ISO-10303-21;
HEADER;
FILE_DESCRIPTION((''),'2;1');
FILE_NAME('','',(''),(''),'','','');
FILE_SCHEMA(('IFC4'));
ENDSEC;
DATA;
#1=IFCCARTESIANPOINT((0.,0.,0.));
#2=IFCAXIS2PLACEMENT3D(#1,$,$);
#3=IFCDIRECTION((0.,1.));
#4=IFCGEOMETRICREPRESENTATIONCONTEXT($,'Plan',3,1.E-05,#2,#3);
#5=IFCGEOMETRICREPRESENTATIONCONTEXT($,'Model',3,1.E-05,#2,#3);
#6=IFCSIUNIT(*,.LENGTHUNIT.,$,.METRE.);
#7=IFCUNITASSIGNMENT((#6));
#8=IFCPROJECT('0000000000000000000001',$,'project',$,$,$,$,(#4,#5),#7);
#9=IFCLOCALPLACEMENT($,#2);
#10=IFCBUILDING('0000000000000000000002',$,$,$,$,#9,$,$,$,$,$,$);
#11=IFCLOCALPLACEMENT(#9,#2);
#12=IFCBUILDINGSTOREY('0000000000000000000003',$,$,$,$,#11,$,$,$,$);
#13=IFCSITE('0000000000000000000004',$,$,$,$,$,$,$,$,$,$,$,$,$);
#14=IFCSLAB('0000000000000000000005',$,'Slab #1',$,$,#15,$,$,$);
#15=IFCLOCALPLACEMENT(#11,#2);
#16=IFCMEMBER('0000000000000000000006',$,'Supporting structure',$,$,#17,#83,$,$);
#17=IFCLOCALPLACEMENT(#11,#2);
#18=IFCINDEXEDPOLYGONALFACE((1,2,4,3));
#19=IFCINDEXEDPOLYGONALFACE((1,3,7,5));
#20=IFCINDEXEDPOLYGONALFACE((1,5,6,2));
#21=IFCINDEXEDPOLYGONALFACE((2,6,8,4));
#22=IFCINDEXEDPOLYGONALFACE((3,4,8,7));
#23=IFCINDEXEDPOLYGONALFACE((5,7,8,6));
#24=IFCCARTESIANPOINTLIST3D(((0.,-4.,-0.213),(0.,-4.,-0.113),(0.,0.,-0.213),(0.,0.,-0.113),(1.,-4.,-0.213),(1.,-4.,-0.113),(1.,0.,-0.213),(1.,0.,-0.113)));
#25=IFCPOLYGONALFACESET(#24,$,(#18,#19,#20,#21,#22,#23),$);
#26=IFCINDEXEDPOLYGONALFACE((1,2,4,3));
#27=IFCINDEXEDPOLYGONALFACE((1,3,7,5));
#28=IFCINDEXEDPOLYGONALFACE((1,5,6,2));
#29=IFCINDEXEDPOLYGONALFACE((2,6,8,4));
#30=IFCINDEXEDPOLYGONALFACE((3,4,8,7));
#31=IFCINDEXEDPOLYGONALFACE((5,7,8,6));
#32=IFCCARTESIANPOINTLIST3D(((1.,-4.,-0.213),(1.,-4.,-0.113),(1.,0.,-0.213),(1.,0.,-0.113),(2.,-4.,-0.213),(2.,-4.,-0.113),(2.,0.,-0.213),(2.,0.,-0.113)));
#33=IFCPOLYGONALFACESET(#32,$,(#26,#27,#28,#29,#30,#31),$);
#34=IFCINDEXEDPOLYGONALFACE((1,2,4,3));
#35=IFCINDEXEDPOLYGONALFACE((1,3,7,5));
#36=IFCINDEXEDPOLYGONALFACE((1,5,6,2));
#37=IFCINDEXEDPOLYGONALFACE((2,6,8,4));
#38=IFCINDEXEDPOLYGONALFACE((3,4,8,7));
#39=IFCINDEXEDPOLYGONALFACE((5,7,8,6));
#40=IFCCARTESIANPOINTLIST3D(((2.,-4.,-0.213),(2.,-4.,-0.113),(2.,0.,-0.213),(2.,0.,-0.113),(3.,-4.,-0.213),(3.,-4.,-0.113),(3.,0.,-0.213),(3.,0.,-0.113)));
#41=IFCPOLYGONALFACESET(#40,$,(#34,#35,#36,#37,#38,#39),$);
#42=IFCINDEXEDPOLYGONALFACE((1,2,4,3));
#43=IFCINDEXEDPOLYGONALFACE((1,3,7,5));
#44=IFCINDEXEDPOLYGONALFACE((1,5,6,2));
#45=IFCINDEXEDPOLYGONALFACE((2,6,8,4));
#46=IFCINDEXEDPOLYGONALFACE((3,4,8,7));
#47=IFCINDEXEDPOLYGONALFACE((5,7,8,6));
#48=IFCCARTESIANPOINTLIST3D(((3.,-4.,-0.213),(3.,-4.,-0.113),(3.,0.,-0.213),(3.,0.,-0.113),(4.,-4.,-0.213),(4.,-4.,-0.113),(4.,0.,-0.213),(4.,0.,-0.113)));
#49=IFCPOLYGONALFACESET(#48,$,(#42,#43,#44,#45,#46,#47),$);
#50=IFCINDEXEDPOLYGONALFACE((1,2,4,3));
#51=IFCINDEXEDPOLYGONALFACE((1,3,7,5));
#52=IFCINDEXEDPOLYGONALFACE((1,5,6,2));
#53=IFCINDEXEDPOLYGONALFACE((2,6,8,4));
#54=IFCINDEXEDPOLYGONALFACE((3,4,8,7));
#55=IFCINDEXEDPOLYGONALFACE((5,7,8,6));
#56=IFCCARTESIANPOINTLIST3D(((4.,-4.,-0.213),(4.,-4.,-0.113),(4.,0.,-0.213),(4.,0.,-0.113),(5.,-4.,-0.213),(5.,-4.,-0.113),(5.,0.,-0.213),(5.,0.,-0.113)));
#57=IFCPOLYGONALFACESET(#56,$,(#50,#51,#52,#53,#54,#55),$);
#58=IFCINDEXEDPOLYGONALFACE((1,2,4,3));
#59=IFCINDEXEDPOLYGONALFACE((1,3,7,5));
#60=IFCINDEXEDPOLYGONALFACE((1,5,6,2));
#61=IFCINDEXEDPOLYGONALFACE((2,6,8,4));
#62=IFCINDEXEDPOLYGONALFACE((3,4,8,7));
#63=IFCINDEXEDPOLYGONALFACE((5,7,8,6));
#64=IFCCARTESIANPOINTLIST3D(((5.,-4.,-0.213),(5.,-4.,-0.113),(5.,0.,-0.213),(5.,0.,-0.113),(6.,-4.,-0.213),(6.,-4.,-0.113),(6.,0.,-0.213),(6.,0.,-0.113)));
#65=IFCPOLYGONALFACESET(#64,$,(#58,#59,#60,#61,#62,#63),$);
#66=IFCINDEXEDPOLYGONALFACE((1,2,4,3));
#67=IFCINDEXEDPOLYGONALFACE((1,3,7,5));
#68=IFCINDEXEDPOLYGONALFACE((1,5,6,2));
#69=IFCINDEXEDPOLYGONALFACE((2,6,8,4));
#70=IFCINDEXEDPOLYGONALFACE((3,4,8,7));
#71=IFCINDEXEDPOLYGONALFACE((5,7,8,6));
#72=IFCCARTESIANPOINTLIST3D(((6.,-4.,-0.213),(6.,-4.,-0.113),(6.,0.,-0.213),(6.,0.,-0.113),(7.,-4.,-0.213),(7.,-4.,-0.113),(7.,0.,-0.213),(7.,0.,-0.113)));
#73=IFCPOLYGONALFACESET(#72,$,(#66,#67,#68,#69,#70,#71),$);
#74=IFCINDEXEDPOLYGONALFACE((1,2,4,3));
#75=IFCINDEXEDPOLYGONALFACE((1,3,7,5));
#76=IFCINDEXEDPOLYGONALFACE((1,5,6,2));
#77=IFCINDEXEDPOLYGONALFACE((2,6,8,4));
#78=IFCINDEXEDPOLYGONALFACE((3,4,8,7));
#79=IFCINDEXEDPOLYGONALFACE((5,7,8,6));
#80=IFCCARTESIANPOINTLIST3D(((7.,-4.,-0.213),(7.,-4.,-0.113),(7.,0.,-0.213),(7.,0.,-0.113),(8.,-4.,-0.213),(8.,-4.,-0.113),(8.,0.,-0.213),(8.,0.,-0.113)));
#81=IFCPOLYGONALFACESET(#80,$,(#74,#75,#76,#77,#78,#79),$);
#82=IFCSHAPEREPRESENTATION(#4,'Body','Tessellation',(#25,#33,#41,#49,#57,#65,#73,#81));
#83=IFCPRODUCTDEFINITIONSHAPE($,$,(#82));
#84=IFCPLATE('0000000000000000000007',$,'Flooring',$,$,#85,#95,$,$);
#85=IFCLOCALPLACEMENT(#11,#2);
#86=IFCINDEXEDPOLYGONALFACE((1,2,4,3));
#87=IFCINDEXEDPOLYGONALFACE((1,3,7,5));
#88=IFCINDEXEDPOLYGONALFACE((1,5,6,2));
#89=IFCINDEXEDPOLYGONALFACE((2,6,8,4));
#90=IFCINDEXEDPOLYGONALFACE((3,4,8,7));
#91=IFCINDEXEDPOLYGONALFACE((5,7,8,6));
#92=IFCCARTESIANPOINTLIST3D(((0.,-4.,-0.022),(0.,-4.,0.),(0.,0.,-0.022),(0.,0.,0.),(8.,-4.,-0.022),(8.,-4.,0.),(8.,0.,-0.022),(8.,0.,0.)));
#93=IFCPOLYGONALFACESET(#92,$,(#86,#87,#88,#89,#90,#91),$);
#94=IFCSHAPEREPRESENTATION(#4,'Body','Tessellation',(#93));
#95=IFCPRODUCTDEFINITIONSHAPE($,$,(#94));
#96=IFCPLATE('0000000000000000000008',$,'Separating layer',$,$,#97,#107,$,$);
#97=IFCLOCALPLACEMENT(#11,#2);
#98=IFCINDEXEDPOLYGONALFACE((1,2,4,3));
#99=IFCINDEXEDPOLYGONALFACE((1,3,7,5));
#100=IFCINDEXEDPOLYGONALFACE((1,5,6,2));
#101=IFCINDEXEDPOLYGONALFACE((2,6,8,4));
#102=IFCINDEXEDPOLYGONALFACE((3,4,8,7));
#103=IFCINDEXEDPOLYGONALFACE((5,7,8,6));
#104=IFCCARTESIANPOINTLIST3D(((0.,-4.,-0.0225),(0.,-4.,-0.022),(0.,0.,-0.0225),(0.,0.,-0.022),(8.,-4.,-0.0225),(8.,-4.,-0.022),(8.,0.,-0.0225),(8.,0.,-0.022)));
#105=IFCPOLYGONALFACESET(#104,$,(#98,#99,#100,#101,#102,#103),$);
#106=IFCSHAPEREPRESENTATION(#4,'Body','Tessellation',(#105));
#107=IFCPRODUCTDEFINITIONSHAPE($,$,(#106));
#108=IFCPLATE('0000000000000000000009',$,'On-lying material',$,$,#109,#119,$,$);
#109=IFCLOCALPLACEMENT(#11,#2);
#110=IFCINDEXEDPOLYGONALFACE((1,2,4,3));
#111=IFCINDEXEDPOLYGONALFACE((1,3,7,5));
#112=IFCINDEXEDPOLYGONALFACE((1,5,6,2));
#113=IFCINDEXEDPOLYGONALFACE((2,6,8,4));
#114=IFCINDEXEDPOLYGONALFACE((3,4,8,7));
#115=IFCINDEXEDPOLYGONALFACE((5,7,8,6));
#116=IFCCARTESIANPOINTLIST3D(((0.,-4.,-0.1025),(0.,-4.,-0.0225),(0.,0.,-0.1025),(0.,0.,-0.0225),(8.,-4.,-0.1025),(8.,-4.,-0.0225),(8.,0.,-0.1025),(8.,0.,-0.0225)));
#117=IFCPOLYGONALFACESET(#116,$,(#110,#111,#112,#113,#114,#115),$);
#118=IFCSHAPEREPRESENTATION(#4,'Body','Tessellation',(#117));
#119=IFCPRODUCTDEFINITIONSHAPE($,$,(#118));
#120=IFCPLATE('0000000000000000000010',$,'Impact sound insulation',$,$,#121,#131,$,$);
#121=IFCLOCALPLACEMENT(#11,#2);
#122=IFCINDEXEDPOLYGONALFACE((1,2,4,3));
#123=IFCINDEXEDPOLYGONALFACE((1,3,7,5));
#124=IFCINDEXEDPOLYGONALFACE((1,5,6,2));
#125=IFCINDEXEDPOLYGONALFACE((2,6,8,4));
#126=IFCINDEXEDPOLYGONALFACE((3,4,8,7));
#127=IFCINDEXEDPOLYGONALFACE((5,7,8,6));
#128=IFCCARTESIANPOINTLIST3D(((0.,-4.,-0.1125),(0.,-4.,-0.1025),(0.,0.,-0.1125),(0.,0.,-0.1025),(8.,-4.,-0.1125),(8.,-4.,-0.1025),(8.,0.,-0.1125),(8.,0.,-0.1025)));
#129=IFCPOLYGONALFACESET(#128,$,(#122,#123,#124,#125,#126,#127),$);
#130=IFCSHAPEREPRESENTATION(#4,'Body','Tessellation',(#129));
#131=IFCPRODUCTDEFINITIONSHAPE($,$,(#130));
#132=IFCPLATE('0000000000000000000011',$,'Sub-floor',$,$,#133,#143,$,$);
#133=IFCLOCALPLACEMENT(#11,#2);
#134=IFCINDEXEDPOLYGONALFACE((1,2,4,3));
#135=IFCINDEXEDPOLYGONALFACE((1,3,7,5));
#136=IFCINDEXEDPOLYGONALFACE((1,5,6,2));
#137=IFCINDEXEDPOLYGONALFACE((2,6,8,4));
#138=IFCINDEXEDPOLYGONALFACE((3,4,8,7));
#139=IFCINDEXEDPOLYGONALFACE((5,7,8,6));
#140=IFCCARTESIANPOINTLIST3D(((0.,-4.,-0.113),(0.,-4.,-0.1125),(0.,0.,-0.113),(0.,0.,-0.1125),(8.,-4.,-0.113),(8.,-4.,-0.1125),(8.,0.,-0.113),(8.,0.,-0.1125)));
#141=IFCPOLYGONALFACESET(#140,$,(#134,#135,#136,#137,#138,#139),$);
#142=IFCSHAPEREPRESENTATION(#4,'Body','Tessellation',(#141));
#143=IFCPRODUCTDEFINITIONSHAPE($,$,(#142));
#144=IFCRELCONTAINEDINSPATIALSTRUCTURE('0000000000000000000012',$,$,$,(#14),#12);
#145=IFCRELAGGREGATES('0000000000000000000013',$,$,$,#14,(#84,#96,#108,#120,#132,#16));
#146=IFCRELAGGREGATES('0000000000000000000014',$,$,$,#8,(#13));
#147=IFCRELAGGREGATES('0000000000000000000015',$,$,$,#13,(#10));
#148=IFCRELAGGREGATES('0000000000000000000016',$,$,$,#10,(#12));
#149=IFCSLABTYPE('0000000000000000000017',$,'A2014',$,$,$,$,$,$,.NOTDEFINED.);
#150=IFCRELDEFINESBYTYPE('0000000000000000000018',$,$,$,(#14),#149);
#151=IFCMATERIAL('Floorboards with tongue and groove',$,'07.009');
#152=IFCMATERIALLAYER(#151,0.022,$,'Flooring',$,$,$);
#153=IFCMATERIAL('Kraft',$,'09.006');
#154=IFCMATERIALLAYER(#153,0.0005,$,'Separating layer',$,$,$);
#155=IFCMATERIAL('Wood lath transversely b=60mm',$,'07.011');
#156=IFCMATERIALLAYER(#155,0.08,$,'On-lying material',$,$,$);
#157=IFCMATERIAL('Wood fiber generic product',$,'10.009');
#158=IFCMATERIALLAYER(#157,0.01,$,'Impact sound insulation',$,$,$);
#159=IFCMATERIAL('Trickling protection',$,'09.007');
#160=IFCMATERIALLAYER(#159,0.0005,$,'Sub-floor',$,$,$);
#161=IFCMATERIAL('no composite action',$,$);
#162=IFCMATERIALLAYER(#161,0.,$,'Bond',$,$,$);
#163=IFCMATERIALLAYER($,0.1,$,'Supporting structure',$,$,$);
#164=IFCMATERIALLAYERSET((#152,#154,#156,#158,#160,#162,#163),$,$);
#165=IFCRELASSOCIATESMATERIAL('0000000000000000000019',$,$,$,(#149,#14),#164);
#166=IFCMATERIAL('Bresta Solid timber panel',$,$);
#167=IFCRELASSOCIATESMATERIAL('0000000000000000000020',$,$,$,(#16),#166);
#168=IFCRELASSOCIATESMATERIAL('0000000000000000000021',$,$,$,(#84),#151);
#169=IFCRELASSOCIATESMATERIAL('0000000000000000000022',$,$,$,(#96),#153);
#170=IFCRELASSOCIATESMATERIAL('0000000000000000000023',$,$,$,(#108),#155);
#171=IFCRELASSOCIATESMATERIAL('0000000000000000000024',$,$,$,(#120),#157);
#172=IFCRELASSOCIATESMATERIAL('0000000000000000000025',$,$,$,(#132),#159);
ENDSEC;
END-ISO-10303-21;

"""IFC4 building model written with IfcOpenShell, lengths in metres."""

from ifc_helpers import new_model, si_unit, direction, frame, frame_2d, origin, origin_with_axes, place, context, project, spatial, rectangle, extrude, material, layer, layer_set, type_object, element, aggregate, save


model = new_model("IFC4")

# Units and contexts
plan_context = context("Plan", 3, precision=1e-05, world=origin(), true_north=direction((0.0, 1.0)))
model_context = context("Model", 3, precision=1e-05, world=origin(), true_north=direction((0.0, 1.0)))
ifc_project = project(units=[si_unit("LENGTHUNIT", "METRE")], contexts=[plan_context, model_context])

# Site, building, storey
site = spatial("IfcSite", under=ifc_project)
building_placement = place(None, origin())
building = spatial("IfcBuilding", under=site, at=building_placement)
storey_placement = place(building_placement, origin())
storey = spatial("IfcBuildingStorey", under=building, at=storey_placement)

# Slab, member, plates
ifc_material_1 = material(Name="Floorboards with tongue and groove", Category="07.009")
ifc_layer_1 = layer(ifc_material_1, 0.022, Name="Flooring")
ifc_material_2 = material(Name="Kraft", Category="09.006")
ifc_layer_2 = layer(ifc_material_2, 0.0005, Name="Separating layer")
ifc_material_3 = material(Name="Wood lath transversely b=60mm", Category="07.011")
ifc_layer_3 = layer(ifc_material_3, 0.08, Name="On-lying material")
ifc_material_4 = material(Name="Wood fiber generic product", Category="10.009")
ifc_layer_4 = layer(ifc_material_4, 0.01, Name="Impact sound insulation")
ifc_material_5 = material(Name="Trickling protection", Category="09.007")
ifc_layer_5 = layer(ifc_material_5, 0.0005, Name="Sub-floor")
ifc_material_6 = material(Name="no composite action")
ifc_layer_6 = layer(ifc_material_6, 0.0, Name="Bond")
ifc_layer_7 = layer(None, 0.1, Name="Supporting structure")
ifc_layer_set = layer_set([ifc_layer_1, ifc_layer_2, ifc_layer_3, ifc_layer_4, ifc_layer_5, ifc_layer_6, ifc_layer_7])
slab_type = type_object("IfcSlabType", Name="A2014", PredefinedType="NOTDEFINED", material=ifc_layer_set)
slab_placement = place(None, frame((0.0, 0.0, 0.0), z_axis=(0.0, 0.0, -1.0), x_axis=(1.0, 0.0, 0.0)))
slab = element("IfcSlab", 1, at=slab_placement, inside=storey, type_object=slab_type, material=ifc_layer_set, Name="Slab #1")
ifc_material_7 = material(Name="Bresta Solid timber panel")
member_placement = place(slab_placement, origin())
member = element("IfcMember", 2, at=member_placement, material=ifc_material_7, Name="Supporting structure", context=plan_context, shape_type="SweptSolid", body=[
    extrude(rectangle(XDim=1.0, YDim=0.1, at=frame_2d((0.5, 0.05), x_axis=(1.0, 0.0))), frame((0.0, 4.0, 0.113), z_axis=(0.0, -1.0, 0.0), x_axis=(1.0, 0.0, 0.0)), (0.0, 0.0, 1.0), 4.0),
    extrude(rectangle(XDim=1.0, YDim=0.1, at=frame_2d((0.5, 0.05), x_axis=(1.0, 0.0))), frame((1.0, 4.0, 0.113), z_axis=(0.0, -1.0, 0.0), x_axis=(1.0, 0.0, 0.0)), (0.0, 0.0, 1.0), 4.0),
    extrude(rectangle(XDim=1.0, YDim=0.1, at=frame_2d((0.5, 0.05), x_axis=(1.0, 0.0))), frame((2.0, 4.0, 0.113), z_axis=(0.0, -1.0, 0.0), x_axis=(1.0, 0.0, 0.0)), (0.0, 0.0, 1.0), 4.0),
    extrude(rectangle(XDim=1.0, YDim=0.1, at=frame_2d((0.5, 0.05), x_axis=(1.0, 0.0))), frame((3.0, 4.0, 0.113), z_axis=(0.0, -1.0, 0.0), x_axis=(1.0, 0.0, 0.0)), (0.0, 0.0, 1.0), 4.0),
    extrude(rectangle(XDim=1.0, YDim=0.1, at=frame_2d((0.5, 0.05), x_axis=(1.0, 0.0))), frame((4.0, 4.0, 0.113), z_axis=(0.0, -1.0, 0.0), x_axis=(1.0, 0.0, 0.0)), (0.0, 0.0, 1.0), 4.0),
    extrude(rectangle(XDim=1.0, YDim=0.1, at=frame_2d((0.5, 0.05), x_axis=(1.0, 0.0))), frame((5.0, 4.0, 0.113), z_axis=(0.0, -1.0, 0.0), x_axis=(1.0, 0.0, 0.0)), (0.0, 0.0, 1.0), 4.0),
    extrude(rectangle(XDim=1.0, YDim=0.1, at=frame_2d((0.5, 0.05), x_axis=(1.0, 0.0))), frame((6.0, 4.0, 0.113), z_axis=(0.0, -1.0, 0.0), x_axis=(1.0, 0.0, 0.0)), (0.0, 0.0, 1.0), 4.0),
    extrude(rectangle(XDim=1.0, YDim=0.1, at=frame_2d((0.5, 0.05), x_axis=(1.0, 0.0))), frame((7.0, 4.0, 0.113), z_axis=(0.0, -1.0, 0.0), x_axis=(1.0, 0.0, 0.0)), (0.0, 0.0, 1.0), 4.0),
])
plate_1_placement = place(slab_placement, origin())
plate_1 = element("IfcPlate", 3, at=plate_1_placement, material=ifc_material_1, Name="Flooring", context=plan_context, shape_type="SweptSolid", body=[
    extrude(rectangle(XDim=8.0, YDim=4.0, at=frame_2d((4.0, 2.0), x_axis=(1.0, 0.0))), origin_with_axes(), (0.0, 0.0, 1.0), 0.022),
])
plate_2_placement = place(slab_placement, origin())
plate_2 = element("IfcPlate", 4, at=plate_2_placement, material=ifc_material_2, Name="Separating layer", context=plan_context, shape_type="SweptSolid", body=[
    extrude(rectangle(XDim=8.0, YDim=4.0, at=frame_2d((4.0, 2.0), x_axis=(1.0, 0.0))), frame((0.0, 0.0, 0.022), z_axis=(0.0, 0.0, 1.0), x_axis=(1.0, 0.0, 0.0)), (0.0, 0.0, 1.0), 0.0005),
])
plate_3_placement = place(slab_placement, origin())
plate_3 = element("IfcPlate", 5, at=plate_3_placement, material=ifc_material_3, Name="On-lying material", context=plan_context, shape_type="SweptSolid", body=[
    extrude(rectangle(XDim=8.0, YDim=4.0, at=frame_2d((4.0, 2.0), x_axis=(1.0, 0.0))), frame((0.0, 0.0, 0.0225), z_axis=(0.0, 0.0, 1.0), x_axis=(1.0, 0.0, 0.0)), (0.0, 0.0, 1.0), 0.08),
])
plate_4_placement = place(slab_placement, origin())
plate_4 = element("IfcPlate", 6, at=plate_4_placement, material=ifc_material_4, Name="Impact sound insulation", context=plan_context, shape_type="SweptSolid", body=[
    extrude(rectangle(XDim=8.0, YDim=4.0, at=frame_2d((4.0, 2.0), x_axis=(1.0, 0.0))), frame((0.0, 0.0, 0.1025), z_axis=(0.0, 0.0, 1.0), x_axis=(1.0, 0.0, 0.0)), (0.0, 0.0, 1.0), 0.01),
])
plate_5_placement = place(slab_placement, origin())
plate_5 = element("IfcPlate", 7, at=plate_5_placement, material=ifc_material_5, Name="Sub-floor", context=plan_context, shape_type="SweptSolid", body=[
    extrude(rectangle(XDim=8.0, YDim=4.0, at=frame_2d((4.0, 2.0), x_axis=(1.0, 0.0))), frame((0.0, 0.0, 0.1125), z_axis=(0.0, 0.0, 1.0), x_axis=(1.0, 0.0, 0.0)), (0.0, 0.0, 1.0), 0.0005),
])
aggregate(slab, [plate_1, plate_2, plate_3, plate_4, plate_5, member])

save(model, "model.ifc")
